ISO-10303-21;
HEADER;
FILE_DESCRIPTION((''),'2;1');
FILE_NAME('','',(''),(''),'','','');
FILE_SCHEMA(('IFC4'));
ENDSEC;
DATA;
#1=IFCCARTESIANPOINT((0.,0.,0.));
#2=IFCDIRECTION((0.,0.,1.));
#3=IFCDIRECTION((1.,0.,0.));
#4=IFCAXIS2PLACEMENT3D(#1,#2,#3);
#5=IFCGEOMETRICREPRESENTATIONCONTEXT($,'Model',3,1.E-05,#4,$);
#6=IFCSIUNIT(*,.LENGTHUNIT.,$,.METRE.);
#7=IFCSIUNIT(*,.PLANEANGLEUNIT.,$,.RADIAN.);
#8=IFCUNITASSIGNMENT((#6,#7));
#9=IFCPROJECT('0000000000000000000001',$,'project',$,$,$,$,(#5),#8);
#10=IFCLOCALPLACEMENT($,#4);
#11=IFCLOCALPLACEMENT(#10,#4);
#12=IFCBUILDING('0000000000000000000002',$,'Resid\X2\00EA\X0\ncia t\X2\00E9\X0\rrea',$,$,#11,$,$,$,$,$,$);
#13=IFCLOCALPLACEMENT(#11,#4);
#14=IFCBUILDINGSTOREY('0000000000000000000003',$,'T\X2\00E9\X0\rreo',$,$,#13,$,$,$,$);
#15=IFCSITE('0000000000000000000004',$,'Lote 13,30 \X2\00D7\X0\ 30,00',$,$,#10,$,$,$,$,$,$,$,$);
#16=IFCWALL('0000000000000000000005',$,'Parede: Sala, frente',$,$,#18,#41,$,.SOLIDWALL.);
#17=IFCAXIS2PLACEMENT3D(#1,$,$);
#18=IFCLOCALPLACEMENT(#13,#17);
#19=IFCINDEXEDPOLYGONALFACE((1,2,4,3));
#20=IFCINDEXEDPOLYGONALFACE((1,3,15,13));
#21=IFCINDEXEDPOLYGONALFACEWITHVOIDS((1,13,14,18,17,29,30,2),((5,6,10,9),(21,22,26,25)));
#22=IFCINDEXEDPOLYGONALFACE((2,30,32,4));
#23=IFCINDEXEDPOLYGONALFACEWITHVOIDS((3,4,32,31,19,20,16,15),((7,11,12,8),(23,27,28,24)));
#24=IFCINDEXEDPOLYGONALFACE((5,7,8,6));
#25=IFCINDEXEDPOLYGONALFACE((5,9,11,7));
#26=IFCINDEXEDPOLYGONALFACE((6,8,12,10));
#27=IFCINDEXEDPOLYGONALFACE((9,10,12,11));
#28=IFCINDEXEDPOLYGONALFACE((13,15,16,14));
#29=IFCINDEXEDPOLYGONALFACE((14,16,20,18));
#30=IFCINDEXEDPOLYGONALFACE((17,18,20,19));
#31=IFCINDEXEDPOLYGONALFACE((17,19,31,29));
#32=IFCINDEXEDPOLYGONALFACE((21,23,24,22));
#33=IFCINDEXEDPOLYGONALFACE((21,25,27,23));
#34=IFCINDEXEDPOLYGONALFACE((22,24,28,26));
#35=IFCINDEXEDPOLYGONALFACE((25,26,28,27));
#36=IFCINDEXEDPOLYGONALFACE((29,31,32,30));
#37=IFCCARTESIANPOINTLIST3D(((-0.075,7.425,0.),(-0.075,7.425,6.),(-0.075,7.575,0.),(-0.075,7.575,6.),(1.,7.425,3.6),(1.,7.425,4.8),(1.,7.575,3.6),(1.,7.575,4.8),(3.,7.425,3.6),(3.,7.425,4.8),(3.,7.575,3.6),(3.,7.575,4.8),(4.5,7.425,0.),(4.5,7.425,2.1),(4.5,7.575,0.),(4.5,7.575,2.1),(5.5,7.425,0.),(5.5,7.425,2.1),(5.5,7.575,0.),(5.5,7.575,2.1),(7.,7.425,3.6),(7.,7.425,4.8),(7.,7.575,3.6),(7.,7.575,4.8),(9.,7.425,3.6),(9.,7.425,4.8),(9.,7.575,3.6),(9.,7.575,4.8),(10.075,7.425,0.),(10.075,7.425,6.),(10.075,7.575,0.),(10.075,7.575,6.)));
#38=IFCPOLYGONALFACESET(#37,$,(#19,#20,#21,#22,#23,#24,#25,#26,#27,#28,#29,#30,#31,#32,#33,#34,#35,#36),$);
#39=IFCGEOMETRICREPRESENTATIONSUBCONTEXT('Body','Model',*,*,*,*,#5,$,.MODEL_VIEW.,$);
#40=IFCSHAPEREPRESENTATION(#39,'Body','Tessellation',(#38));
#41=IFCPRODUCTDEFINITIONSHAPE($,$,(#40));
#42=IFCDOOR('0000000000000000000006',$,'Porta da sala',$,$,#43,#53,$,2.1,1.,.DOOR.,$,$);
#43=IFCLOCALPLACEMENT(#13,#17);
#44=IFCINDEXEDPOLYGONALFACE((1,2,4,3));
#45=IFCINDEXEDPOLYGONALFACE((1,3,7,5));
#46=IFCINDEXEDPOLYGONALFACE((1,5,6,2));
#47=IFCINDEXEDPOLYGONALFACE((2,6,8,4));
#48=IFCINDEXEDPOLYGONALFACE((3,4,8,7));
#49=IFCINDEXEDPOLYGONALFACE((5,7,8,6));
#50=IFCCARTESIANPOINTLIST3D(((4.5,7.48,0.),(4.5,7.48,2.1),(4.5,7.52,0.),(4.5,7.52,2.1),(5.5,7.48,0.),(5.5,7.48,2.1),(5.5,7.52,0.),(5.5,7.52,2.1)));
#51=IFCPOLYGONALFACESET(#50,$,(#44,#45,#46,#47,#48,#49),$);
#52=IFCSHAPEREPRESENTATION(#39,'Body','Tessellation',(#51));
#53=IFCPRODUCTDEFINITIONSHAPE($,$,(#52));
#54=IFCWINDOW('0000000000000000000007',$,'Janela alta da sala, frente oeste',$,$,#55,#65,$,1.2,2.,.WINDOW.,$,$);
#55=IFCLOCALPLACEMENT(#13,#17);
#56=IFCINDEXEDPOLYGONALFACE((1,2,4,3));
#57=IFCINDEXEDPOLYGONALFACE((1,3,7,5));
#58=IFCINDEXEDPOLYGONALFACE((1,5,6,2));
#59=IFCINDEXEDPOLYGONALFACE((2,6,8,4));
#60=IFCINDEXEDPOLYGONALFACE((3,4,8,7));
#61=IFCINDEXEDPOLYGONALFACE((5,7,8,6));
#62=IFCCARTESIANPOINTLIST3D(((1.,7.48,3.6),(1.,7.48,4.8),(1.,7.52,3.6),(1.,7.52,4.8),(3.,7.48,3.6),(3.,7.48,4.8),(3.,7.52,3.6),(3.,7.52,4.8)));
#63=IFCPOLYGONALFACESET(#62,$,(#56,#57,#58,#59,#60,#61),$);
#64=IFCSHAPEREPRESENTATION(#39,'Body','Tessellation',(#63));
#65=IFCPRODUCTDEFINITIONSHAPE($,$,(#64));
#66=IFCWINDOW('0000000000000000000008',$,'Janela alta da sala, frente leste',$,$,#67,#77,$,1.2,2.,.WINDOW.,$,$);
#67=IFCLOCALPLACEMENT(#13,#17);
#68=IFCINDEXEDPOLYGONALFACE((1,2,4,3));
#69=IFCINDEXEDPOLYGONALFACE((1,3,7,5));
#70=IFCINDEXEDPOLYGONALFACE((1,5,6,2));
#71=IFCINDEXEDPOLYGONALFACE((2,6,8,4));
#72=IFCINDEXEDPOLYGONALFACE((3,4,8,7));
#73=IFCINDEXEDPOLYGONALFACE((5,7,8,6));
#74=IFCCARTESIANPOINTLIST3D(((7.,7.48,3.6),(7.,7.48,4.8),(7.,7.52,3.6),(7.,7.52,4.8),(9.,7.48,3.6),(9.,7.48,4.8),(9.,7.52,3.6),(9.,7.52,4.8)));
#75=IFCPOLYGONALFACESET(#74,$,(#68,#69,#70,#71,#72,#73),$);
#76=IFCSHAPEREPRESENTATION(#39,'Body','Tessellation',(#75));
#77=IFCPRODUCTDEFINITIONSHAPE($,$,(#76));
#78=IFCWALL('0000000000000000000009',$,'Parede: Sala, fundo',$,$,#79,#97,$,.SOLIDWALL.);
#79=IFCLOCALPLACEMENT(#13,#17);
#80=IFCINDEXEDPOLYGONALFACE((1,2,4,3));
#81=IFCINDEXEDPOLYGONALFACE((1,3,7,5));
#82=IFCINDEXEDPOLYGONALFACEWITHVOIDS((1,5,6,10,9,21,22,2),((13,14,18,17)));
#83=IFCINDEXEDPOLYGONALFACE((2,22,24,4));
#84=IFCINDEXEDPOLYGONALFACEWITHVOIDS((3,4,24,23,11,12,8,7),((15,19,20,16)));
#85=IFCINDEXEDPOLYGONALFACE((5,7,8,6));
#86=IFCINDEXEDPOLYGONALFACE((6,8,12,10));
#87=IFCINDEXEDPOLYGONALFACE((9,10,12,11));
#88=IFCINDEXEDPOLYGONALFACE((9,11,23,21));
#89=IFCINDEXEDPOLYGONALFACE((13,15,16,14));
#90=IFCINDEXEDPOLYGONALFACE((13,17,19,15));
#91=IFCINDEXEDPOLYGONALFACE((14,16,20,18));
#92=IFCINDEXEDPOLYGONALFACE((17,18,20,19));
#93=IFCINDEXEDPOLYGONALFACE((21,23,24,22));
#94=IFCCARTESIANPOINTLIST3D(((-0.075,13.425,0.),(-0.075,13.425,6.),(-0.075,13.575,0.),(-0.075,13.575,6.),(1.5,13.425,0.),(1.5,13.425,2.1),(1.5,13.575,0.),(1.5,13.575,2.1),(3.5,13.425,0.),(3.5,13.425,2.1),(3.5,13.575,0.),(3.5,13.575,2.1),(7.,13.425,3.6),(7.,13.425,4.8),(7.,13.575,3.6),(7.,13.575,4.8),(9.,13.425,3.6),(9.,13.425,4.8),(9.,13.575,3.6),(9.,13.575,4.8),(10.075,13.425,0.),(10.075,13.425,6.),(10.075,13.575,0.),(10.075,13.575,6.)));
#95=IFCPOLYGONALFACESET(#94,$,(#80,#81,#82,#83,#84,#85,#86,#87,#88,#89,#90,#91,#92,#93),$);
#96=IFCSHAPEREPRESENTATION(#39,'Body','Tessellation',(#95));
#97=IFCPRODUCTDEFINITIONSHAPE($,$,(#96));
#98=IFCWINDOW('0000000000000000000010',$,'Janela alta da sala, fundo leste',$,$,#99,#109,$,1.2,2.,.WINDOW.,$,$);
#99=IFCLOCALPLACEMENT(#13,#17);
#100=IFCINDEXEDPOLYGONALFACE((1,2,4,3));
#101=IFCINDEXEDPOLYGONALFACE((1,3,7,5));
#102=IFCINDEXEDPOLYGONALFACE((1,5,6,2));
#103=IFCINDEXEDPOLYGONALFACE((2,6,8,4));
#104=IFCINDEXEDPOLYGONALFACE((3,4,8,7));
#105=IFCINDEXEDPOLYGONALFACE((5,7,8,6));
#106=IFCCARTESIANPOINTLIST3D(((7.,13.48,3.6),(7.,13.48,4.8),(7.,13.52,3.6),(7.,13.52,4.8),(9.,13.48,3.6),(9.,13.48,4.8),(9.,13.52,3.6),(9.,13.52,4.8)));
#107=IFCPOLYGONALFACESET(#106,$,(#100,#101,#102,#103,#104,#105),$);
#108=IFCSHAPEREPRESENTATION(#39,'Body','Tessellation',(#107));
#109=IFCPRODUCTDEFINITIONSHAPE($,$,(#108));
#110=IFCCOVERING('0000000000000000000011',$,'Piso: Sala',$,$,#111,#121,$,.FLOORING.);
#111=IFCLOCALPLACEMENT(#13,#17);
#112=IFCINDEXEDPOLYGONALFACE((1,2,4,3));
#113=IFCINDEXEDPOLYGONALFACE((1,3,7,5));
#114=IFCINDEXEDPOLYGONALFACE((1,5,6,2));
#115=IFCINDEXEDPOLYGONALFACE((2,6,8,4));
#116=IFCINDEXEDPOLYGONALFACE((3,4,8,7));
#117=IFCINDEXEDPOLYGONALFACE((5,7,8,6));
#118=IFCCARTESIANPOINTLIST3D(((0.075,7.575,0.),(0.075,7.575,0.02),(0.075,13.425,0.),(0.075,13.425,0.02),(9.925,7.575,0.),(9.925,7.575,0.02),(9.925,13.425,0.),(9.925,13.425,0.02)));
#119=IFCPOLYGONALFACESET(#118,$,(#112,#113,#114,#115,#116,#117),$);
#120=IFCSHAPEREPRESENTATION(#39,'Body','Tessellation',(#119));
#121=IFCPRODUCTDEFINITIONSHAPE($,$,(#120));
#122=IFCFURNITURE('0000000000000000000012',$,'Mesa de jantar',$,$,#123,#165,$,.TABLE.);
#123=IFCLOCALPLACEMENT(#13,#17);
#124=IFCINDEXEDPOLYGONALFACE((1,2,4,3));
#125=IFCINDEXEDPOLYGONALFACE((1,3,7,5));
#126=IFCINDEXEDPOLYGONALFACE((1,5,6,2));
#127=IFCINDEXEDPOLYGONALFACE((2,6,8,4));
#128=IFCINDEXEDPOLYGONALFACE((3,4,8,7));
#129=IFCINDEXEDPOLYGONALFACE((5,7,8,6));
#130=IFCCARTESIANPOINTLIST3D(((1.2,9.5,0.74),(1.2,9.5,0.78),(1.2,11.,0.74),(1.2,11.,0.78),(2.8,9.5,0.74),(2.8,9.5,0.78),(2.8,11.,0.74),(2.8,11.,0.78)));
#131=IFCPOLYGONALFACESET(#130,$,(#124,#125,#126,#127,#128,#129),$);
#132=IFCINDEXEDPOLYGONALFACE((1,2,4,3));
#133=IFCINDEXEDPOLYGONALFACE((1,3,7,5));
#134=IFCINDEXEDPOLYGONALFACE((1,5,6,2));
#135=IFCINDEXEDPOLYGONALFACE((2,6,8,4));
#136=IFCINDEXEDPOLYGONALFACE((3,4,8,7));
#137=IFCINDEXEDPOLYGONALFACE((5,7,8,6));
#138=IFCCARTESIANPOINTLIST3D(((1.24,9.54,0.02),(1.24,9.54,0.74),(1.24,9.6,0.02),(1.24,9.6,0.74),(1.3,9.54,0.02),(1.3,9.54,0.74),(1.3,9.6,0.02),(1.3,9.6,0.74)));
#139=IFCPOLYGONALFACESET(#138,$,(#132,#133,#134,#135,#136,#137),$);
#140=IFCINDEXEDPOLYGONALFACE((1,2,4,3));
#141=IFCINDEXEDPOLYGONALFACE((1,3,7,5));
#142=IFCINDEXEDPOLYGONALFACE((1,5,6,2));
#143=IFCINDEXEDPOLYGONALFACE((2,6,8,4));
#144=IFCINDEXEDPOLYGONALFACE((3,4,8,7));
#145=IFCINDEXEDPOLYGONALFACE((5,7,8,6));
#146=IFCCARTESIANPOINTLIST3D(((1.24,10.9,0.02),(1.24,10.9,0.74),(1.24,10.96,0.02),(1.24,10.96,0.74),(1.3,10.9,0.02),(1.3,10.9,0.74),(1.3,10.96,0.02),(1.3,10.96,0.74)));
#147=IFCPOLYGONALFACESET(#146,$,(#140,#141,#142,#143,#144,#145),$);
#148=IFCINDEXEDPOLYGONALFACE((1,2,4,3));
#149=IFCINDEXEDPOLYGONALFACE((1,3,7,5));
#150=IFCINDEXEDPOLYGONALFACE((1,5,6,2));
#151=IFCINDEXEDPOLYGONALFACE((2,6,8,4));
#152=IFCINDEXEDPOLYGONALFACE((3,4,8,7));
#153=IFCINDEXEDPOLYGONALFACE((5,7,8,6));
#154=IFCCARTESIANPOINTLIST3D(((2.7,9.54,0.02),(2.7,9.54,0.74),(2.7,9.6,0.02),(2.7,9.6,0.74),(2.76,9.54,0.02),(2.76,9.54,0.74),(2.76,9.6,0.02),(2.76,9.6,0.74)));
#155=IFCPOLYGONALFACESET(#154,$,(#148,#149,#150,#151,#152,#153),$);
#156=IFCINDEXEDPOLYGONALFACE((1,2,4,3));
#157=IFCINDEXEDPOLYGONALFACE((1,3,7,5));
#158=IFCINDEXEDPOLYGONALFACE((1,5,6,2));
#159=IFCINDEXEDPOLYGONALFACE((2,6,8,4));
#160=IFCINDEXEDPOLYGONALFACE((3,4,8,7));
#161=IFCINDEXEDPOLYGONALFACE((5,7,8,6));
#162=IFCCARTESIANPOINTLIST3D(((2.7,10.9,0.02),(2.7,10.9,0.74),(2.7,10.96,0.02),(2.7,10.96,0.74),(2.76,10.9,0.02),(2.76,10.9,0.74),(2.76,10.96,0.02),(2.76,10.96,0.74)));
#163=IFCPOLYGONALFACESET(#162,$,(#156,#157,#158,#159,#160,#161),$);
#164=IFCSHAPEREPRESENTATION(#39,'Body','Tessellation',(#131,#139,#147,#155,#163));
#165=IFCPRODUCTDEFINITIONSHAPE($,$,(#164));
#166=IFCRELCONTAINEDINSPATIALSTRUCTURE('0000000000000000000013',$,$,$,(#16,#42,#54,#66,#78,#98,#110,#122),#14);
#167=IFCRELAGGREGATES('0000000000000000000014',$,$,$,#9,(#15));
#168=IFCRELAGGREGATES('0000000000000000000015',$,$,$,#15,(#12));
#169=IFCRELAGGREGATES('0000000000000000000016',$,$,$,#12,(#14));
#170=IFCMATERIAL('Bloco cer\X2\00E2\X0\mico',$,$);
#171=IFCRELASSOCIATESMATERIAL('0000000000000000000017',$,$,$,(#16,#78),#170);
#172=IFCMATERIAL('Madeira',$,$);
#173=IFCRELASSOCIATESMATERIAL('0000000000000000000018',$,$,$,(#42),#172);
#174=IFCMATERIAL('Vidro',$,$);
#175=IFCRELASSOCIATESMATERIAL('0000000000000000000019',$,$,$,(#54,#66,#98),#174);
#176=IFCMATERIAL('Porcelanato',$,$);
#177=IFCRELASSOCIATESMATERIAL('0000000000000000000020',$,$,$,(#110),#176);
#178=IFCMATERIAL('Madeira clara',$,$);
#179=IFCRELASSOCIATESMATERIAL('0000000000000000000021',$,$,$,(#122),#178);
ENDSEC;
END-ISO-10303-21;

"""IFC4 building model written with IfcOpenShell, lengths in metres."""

from ifc_helpers import new_model, si_unit, frame, origin_with_axes, place, context, subcontext, project, spatial, line, indexed_curve, outline, extrude, material, element, fill, save


model = new_model("IFC4")

# Units and contexts
model_context = context("Model", 3, precision=1e-05, world=origin_with_axes())
body_context = subcontext(model_context, "Body", "Model", "MODEL_VIEW")
ifc_project = project(units=[si_unit("LENGTHUNIT", "METRE"), si_unit("PLANEANGLEUNIT", "RADIAN")], contexts=[model_context])

# Site, building, storey
site_placement = place(None, origin_with_axes())
site = spatial("IfcSite", under=ifc_project, at=site_placement, Name="Lote 13,30 × 30,00")
building_placement = place(site_placement, origin_with_axes())
building = spatial("IfcBuilding", under=site, at=building_placement, Name="Residência térrea")
storey_placement = place(building_placement, origin_with_axes())
storey = spatial("IfcBuildingStorey", under=building, at=storey_placement, Name="Térreo")

# Shared definitions
ifc_material_1 = material(Name="Concreto armado")

# Shared definitions
ifc_material_2 = material(Name="Bloco cerâmico")
ifc_material_3 = material(Name="Vidro")

# Wall, openings, door, windows
wall_1_placement = place(storey_placement, frame((-0.075, 7.425, 0.0), z_axis=(0.0, 0.0, 1.0), x_axis=(1.0, 0.0, 0.0)))
wall_1 = element("IfcWall", 1, at=wall_1_placement, inside=storey, material=ifc_material_2, Name="Parede: Sala, frente", PredefinedType="SOLIDWALL", context=body_context, shape_type="SweptSolid", body=[
    extrude(outline(indexed_curve([(0.0, 0.0), (10.15, 0.0), (10.15, 0.15), (0.0, 0.15)], segments=[line(1, 2, 3, 4, 1)])), origin_with_axes(), (0.0, 0.0, 1.0), 6.0),
])
opening_1_placement = place(wall_1_placement, frame((4.575, -0.05, 0.0), z_axis=(0.0, 0.0, 1.0), x_axis=(1.0, 0.0, 0.0)))
opening_1 = element("IfcOpeningElement", 2, at=opening_1_placement, cuts=wall_1, material=ifc_material_1, PredefinedType="OPENING", context=body_context, shape_type="SweptSolid", body=[
    extrude(outline(indexed_curve([(0.0, 0.0), (1.0, 0.0), (1.0, 0.25), (0.0, 0.25)], segments=[line(1, 2, 3, 4, 1)])), origin_with_axes(), (0.0, 0.0, 1.0), 2.1),
])
opening_2_placement = place(wall_1_placement, frame((1.075, -0.05, 3.6), z_axis=(0.0, 0.0, 1.0), x_axis=(1.0, 0.0, 0.0)))
opening_2 = element("IfcOpeningElement", 3, at=opening_2_placement, cuts=wall_1, material=ifc_material_1, PredefinedType="OPENING", context=body_context, shape_type="SweptSolid", body=[
    extrude(outline(indexed_curve([(0.0, 0.0), (2.0, 0.0), (2.0, 0.25), (0.0, 0.25)], segments=[line(1, 2, 3, 4, 1)])), origin_with_axes(), (0.0, 0.0, 1.0), 1.2),
])
opening_3_placement = place(wall_1_placement, frame((7.075, -0.05, 3.6), z_axis=(0.0, 0.0, 1.0), x_axis=(1.0, 0.0, 0.0)))
opening_3 = element("IfcOpeningElement", 4, at=opening_3_placement, cuts=wall_1, material=ifc_material_1, PredefinedType="OPENING", context=body_context, shape_type="SweptSolid", body=[
    extrude(outline(indexed_curve([(0.0, 0.0), (2.0, 0.0), (2.0, 0.25), (0.0, 0.25)], segments=[line(1, 2, 3, 4, 1)])), origin_with_axes(), (0.0, 0.0, 1.0), 1.2),
])
ifc_material_4 = material(Name="Madeira")
door_placement = place(storey_placement, frame((4.5, 7.48, 0.0), z_axis=(0.0, 0.0, 1.0), x_axis=(1.0, 0.0, 0.0)))
door = element("IfcDoor", 5, at=door_placement, inside=storey, material=ifc_material_4, Name="Porta da sala", OverallHeight=2.1, OverallWidth=1.0, PredefinedType="DOOR", context=body_context, shape_type="SweptSolid", body=[
    extrude(outline(indexed_curve([(0.0, 0.0), (1.0, 0.0), (1.0, 0.04), (0.0, 0.04)], segments=[line(1, 2, 3, 4, 1)])), origin_with_axes(), (0.0, 0.0, 1.0), 2.1),
])
fill(opening_1, door)
window_1_placement = place(storey_placement, frame((1.0, 7.48, 3.6), z_axis=(0.0, 0.0, 1.0), x_axis=(1.0, 0.0, 0.0)))
window_1 = element("IfcWindow", 6, at=window_1_placement, inside=storey, material=ifc_material_3, Name="Janela alta da sala, frente oeste", OverallHeight=1.2, OverallWidth=2.0, PredefinedType="WINDOW", context=body_context, shape_type="SweptSolid", body=[
    extrude(outline(indexed_curve([(0.0, 0.0), (2.0, 0.0), (2.0, 0.04), (0.0, 0.04)], segments=[line(1, 2, 3, 4, 1)])), origin_with_axes(), (0.0, 0.0, 1.0), 1.2),
])
fill(opening_2, window_1)
window_2_placement = place(storey_placement, frame((7.0, 7.48, 3.6), z_axis=(0.0, 0.0, 1.0), x_axis=(1.0, 0.0, 0.0)))
window_2 = element("IfcWindow", 7, at=window_2_placement, inside=storey, material=ifc_material_3, Name="Janela alta da sala, frente leste", OverallHeight=1.2, OverallWidth=2.0, PredefinedType="WINDOW", context=body_context, shape_type="SweptSolid", body=[
    extrude(outline(indexed_curve([(0.0, 0.0), (2.0, 0.0), (2.0, 0.04), (0.0, 0.04)], segments=[line(1, 2, 3, 4, 1)])), origin_with_axes(), (0.0, 0.0, 1.0), 1.2),
])
fill(opening_3, window_2)

# Wall, openings, window
wall_2_placement = place(storey_placement, frame((-0.075, 13.425, 0.0), z_axis=(0.0, 0.0, 1.0), x_axis=(1.0, 0.0, 0.0)))
wall_2 = element("IfcWall", 8, at=wall_2_placement, inside=storey, material=ifc_material_2, Name="Parede: Sala, fundo", PredefinedType="SOLIDWALL", context=body_context, shape_type="SweptSolid", body=[
    extrude(outline(indexed_curve([(0.0, 0.0), (10.15, 0.0), (10.15, 0.15), (0.0, 0.15)], segments=[line(1, 2, 3, 4, 1)])), origin_with_axes(), (0.0, 0.0, 1.0), 6.0),
])
opening_4_placement = place(wall_2_placement, frame((1.575, -0.05, 0.0), z_axis=(0.0, 0.0, 1.0), x_axis=(1.0, 0.0, 0.0)))
element("IfcOpeningElement", 9, at=opening_4_placement, cuts=wall_2, material=ifc_material_1, PredefinedType="OPENING", context=body_context, shape_type="SweptSolid", body=[
    extrude(outline(indexed_curve([(0.0, 0.0), (2.0, 0.0), (2.0, 0.25), (0.0, 0.25)], segments=[line(1, 2, 3, 4, 1)])), origin_with_axes(), (0.0, 0.0, 1.0), 2.1),
])
opening_5_placement = place(wall_2_placement, frame((7.075, -0.05, 3.6), z_axis=(0.0, 0.0, 1.0), x_axis=(1.0, 0.0, 0.0)))
opening_5 = element("IfcOpeningElement", 10, at=opening_5_placement, cuts=wall_2, material=ifc_material_1, PredefinedType="OPENING", context=body_context, shape_type="SweptSolid", body=[
    extrude(outline(indexed_curve([(0.0, 0.0), (2.0, 0.0), (2.0, 0.25), (0.0, 0.25)], segments=[line(1, 2, 3, 4, 1)])), origin_with_axes(), (0.0, 0.0, 1.0), 1.2),
])
window_3_placement = place(storey_placement, frame((7.0, 13.48, 3.6), z_axis=(0.0, 0.0, 1.0), x_axis=(1.0, 0.0, 0.0)))
window_3 = element("IfcWindow", 11, at=window_3_placement, inside=storey, material=ifc_material_3, Name="Janela alta da sala, fundo leste", OverallHeight=1.2, OverallWidth=2.0, PredefinedType="WINDOW", context=body_context, shape_type="SweptSolid", body=[
    extrude(outline(indexed_curve([(0.0, 0.0), (2.0, 0.0), (2.0, 0.04), (0.0, 0.04)], segments=[line(1, 2, 3, 4, 1)])), origin_with_axes(), (0.0, 0.0, 1.0), 1.2),
])
fill(opening_5, window_3)

# Covering
ifc_material_5 = material(Name="Porcelanato")
covering_placement = place(storey_placement, frame((0.075, 7.575, 0.0), z_axis=(0.0, 0.0, 1.0), x_axis=(1.0, 0.0, 0.0)))
element("IfcCovering", 12, at=covering_placement, inside=storey, material=ifc_material_5, Name="Piso: Sala", PredefinedType="FLOORING", context=body_context, shape_type="SweptSolid", body=[
    extrude(outline(indexed_curve([(0.0, 0.0), (9.85, 0.0), (9.85, 5.85), (0.0, 5.85)], segments=[line(1, 2, 3, 4, 1)])), origin_with_axes(), (0.0, 0.0, 1.0), 0.02),
])

# Furniture
ifc_material_6 = material(Name="Madeira clara")
furniture_1_placement = place(storey_placement, frame((1.2, 9.5, 0.02), z_axis=(0.0, 0.0, 1.0), x_axis=(1.0, 0.0, 0.0)))
element("IfcFurniture", 13, at=furniture_1_placement, inside=storey, material=ifc_material_6, Name="Mesa de jantar", PredefinedType="TABLE", context=body_context, shape_type="SweptSolid", body=[
    extrude(outline(indexed_curve([(0.0, 0.0), (1.6, 0.0), (1.6, 1.5), (0.0, 1.5)], segments=[line(1, 2, 3, 4, 1)])), frame((0.0, 0.0, 0.72), z_axis=(0.0, 0.0, 1.0), x_axis=(1.0, 0.0, 0.0)), (0.0, 0.0, 1.0), 0.04),
    extrude(outline(indexed_curve([(0.04, 0.04), (0.1, 0.04), (0.1, 0.1), (0.04, 0.1)], segments=[line(1, 2, 3, 4, 1)])), origin_with_axes(), (0.0, 0.0, 1.0), 0.72),
    extrude(outline(indexed_curve([(0.04, 1.4), (0.1, 1.4), (0.1, 1.46), (0.04, 1.46)], segments=[line(1, 2, 3, 4, 1)])), origin_with_axes(), (0.0, 0.0, 1.0), 0.72),
    extrude(outline(indexed_curve([(1.5, 0.04), (1.56, 0.04), (1.56, 0.1), (1.5, 0.1)], segments=[line(1, 2, 3, 4, 1)])), origin_with_axes(), (0.0, 0.0, 1.0), 0.72),
    extrude(outline(indexed_curve([(1.5, 1.4), (1.56, 1.4), (1.56, 1.46), (1.5, 1.46)], segments=[line(1, 2, 3, 4, 1)])), origin_with_axes(), (0.0, 0.0, 1.0), 0.72),
])

save(model, "model.ifc")
